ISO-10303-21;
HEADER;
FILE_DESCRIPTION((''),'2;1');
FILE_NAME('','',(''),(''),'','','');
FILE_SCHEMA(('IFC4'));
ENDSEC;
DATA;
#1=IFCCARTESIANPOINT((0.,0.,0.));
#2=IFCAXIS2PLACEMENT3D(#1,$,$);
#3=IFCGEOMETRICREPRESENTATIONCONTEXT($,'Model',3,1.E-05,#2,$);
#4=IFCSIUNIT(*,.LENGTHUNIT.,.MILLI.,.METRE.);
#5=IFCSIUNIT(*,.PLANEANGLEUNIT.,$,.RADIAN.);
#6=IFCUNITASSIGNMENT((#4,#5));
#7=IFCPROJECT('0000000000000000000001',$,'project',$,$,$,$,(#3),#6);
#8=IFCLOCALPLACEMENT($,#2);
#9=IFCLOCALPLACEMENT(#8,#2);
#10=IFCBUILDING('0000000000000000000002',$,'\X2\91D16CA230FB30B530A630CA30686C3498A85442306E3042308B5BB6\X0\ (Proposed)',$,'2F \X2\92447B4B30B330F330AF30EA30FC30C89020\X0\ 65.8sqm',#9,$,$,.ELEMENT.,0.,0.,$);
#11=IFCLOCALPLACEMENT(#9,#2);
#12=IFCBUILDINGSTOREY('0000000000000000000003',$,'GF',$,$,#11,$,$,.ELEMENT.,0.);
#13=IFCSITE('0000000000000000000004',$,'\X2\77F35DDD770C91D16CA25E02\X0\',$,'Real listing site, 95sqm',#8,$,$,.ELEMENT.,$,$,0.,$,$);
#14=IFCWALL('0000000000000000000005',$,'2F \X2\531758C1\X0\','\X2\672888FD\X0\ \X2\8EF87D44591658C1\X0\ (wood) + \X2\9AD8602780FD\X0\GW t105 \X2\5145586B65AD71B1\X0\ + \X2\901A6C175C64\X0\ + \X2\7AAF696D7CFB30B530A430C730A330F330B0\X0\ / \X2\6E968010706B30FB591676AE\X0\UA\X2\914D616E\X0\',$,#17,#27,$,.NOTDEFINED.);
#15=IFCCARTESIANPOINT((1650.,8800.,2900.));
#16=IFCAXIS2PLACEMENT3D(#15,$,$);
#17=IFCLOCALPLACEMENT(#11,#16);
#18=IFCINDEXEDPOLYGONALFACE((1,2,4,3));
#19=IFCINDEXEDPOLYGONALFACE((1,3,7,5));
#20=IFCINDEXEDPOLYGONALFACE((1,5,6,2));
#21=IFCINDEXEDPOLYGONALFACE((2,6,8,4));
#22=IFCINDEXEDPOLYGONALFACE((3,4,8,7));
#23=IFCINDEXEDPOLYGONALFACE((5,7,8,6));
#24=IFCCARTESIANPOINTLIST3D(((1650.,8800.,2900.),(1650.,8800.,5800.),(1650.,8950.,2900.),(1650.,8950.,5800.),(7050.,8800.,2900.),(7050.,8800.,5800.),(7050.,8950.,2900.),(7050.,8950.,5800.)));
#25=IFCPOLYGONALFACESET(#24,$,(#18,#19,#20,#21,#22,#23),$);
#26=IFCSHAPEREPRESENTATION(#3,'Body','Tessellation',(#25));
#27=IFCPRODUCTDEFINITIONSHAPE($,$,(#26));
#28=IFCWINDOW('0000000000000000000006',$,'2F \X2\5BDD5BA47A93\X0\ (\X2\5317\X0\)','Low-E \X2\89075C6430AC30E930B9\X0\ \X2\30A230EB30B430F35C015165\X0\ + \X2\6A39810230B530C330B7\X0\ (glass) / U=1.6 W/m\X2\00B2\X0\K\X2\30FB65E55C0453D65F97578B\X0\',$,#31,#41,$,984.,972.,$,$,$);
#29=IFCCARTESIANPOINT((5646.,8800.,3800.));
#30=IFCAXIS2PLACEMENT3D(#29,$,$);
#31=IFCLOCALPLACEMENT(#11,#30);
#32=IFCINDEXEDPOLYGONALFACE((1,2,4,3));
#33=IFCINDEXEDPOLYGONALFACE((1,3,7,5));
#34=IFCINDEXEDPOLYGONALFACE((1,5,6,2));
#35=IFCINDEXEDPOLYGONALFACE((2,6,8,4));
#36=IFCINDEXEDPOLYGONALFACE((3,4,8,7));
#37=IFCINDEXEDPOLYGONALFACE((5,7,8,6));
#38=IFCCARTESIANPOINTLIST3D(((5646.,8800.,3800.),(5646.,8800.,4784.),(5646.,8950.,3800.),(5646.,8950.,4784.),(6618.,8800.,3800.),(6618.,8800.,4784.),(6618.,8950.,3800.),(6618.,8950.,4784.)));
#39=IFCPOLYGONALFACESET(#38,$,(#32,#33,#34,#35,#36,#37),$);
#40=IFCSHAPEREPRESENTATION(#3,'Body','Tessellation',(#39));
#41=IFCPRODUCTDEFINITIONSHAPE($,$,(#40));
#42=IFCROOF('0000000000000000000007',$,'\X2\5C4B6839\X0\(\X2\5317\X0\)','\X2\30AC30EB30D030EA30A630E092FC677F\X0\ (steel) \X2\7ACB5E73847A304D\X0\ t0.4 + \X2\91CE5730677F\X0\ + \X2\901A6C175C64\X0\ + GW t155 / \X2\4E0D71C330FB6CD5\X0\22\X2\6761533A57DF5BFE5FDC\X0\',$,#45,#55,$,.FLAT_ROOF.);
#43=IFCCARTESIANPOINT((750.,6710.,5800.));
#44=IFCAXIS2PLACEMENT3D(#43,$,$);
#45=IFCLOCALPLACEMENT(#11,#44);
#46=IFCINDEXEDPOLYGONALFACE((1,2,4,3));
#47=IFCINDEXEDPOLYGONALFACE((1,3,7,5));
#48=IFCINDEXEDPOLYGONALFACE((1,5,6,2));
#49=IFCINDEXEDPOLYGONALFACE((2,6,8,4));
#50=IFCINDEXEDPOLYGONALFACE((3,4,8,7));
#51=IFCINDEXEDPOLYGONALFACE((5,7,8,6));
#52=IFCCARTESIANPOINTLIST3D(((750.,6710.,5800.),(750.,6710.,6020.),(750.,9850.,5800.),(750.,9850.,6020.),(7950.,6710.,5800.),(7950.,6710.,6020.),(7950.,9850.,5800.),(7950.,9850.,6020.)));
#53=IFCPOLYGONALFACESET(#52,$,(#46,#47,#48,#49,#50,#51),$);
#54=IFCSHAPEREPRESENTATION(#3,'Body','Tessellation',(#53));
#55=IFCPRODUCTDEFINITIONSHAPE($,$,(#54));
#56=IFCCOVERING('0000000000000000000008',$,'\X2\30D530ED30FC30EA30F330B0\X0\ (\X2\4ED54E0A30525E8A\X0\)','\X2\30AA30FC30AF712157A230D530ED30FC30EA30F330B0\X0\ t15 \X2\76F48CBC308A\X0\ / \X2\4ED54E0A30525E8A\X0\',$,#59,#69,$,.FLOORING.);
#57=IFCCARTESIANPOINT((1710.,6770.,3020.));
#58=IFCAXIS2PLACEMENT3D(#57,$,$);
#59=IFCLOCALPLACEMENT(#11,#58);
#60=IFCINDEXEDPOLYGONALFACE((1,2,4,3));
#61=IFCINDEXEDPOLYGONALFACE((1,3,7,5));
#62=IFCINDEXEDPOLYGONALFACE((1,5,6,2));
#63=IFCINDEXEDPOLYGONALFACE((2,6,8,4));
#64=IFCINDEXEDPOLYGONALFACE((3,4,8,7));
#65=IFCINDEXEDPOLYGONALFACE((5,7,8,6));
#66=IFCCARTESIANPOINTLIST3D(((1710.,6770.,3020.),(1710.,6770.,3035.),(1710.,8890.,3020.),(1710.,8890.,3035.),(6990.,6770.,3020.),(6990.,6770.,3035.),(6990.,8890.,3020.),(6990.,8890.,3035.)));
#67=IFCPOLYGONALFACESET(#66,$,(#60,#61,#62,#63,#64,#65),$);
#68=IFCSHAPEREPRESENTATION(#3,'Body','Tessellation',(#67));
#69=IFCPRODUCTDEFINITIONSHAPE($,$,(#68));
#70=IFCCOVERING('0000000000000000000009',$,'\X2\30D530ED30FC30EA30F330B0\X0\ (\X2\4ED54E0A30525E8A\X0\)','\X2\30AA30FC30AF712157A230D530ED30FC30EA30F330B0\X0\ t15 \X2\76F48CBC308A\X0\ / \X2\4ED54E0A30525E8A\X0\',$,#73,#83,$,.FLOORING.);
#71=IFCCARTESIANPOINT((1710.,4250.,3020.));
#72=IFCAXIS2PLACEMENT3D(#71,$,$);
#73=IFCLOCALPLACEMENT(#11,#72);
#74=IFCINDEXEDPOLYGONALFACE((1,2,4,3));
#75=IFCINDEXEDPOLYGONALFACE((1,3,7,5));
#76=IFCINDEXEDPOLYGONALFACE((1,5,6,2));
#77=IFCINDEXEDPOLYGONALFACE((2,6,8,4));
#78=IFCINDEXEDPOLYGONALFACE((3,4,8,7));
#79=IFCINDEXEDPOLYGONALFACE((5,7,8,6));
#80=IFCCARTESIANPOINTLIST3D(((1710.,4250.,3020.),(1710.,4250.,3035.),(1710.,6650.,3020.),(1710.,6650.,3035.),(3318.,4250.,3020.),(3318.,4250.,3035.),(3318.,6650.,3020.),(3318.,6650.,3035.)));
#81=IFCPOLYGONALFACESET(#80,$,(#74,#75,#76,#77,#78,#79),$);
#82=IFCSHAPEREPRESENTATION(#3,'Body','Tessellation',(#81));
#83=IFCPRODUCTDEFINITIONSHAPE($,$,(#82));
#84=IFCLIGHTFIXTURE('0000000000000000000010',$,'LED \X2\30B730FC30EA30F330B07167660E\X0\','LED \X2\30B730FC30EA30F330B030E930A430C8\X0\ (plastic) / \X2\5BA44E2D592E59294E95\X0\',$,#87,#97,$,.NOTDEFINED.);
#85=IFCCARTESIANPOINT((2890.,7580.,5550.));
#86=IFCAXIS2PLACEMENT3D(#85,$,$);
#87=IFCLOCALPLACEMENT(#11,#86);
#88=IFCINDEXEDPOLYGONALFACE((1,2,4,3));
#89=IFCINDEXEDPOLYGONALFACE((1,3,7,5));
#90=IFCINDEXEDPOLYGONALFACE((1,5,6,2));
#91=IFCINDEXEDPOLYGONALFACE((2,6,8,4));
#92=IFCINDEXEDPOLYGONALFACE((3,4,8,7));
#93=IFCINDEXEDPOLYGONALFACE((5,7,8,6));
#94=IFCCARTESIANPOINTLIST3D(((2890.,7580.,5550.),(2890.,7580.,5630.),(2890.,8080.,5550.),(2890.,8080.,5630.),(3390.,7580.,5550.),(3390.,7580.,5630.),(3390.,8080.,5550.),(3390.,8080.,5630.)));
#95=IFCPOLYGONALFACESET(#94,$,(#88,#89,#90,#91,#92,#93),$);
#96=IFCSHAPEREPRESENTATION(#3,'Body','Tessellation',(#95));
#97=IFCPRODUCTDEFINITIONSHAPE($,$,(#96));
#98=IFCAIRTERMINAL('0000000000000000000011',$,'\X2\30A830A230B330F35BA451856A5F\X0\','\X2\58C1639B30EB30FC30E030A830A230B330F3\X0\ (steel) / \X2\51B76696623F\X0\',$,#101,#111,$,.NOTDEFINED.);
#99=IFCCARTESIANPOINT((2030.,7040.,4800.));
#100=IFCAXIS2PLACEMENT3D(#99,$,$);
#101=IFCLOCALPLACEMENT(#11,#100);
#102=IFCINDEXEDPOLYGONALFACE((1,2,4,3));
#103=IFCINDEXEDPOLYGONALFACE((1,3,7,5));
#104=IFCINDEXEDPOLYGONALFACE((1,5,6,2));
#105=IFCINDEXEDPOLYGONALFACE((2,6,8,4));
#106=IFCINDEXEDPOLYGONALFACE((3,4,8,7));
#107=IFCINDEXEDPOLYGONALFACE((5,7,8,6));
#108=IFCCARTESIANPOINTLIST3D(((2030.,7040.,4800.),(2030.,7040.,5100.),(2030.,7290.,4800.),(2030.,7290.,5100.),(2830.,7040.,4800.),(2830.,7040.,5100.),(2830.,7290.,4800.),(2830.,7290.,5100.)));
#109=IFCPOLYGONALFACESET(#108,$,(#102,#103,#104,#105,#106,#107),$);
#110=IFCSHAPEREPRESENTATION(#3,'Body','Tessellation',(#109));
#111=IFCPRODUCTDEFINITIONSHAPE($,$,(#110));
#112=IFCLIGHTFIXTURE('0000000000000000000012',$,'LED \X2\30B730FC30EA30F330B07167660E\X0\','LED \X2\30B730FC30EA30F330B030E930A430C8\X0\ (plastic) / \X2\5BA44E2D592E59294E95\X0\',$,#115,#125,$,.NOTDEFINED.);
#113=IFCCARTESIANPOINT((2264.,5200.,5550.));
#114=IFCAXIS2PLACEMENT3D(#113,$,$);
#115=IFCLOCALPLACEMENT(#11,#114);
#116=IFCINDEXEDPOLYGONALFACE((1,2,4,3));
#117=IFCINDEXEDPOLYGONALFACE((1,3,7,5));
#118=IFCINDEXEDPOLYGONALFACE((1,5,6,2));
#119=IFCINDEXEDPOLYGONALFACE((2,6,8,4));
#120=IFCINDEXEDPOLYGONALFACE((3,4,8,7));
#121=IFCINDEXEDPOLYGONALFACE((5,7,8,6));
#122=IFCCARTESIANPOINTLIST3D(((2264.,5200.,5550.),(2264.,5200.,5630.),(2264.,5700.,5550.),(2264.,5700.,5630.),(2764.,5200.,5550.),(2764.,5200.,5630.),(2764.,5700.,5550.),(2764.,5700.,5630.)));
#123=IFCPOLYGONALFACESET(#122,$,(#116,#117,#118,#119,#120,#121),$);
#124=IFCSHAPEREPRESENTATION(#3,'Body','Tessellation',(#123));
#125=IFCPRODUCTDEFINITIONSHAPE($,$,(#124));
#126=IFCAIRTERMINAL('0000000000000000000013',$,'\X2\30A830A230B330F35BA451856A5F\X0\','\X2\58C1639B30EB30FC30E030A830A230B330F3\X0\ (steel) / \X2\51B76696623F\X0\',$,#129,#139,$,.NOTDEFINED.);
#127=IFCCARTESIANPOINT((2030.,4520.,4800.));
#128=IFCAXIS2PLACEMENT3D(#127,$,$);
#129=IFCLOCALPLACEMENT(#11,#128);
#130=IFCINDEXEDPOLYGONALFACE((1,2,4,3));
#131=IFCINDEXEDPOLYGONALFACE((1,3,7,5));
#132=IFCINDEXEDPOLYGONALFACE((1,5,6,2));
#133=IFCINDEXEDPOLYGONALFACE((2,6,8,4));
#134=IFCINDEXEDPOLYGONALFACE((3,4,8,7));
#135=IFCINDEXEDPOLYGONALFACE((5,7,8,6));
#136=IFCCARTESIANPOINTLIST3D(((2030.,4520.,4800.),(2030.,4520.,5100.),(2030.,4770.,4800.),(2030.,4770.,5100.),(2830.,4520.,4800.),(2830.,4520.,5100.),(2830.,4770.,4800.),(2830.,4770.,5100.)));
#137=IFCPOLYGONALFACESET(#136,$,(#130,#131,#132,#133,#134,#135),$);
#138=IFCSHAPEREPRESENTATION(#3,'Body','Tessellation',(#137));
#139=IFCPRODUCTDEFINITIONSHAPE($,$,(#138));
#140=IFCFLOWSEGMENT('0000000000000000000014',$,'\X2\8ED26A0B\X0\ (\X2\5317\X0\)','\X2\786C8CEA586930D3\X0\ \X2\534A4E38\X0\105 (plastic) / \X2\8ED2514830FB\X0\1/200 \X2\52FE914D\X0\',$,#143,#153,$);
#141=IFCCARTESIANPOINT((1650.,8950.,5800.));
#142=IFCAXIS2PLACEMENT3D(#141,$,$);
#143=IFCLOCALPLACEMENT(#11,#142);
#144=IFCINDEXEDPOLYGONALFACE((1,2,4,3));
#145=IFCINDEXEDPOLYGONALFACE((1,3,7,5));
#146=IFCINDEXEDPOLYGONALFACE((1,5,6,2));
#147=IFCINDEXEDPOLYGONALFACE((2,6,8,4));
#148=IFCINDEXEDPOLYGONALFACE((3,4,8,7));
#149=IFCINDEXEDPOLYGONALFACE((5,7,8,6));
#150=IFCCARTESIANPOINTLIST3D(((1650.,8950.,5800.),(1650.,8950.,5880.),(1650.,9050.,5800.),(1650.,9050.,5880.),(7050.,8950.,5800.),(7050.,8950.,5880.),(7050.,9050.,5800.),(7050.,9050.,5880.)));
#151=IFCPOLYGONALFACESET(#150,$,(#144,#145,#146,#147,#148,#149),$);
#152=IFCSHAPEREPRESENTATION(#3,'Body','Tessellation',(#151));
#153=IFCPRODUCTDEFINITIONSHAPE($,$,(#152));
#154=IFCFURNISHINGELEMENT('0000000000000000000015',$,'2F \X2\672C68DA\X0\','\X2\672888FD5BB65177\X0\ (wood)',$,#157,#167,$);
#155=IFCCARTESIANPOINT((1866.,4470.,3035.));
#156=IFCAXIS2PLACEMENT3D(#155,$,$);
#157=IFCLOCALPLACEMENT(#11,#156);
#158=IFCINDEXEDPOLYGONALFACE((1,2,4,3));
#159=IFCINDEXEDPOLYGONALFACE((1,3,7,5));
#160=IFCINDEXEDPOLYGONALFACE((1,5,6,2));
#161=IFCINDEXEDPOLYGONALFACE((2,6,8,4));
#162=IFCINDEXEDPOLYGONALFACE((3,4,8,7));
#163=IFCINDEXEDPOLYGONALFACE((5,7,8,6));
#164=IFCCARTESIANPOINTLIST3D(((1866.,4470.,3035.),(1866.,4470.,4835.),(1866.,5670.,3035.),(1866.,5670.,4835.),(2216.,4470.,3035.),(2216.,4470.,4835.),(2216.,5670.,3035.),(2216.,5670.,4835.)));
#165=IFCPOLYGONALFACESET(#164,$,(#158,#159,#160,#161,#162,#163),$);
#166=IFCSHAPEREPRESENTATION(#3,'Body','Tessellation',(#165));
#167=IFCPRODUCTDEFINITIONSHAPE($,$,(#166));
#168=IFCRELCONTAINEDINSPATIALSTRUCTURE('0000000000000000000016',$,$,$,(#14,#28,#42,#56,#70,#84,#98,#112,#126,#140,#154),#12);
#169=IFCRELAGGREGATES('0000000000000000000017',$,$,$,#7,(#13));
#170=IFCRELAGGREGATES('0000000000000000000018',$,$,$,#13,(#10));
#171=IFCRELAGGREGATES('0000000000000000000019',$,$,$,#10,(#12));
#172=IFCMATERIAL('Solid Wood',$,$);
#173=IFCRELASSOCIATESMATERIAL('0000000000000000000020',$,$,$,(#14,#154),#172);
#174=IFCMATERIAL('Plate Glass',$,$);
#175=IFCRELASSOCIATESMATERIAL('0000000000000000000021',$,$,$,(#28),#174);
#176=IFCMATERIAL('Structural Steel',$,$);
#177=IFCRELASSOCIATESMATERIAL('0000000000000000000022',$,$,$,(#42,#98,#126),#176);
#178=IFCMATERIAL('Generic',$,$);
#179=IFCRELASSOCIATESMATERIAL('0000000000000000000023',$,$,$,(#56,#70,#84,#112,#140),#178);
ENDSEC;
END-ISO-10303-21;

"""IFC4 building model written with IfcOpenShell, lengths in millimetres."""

from ifc_helpers import new_model, si_unit, frame, frame_2d, origin, place, context, project, spatial, rectangle, extrude, material, element, fill, save


model = new_model("IFC4")

# Units and contexts
model_context = context("Model", 3, precision=1e-05, world=origin())
ifc_project = project(units=[si_unit("LENGTHUNIT", "METRE", prefix="MILLI"), si_unit("PLANEANGLEUNIT", "RADIAN")], contexts=[model_context])

# Site, building, storey
site_placement = place(None, origin())
site = spatial("IfcSite", under=ifc_project, at=site_placement, Name="石川県金沢市", ObjectType="Real listing site, 95sqm", CompositionType="ELEMENT", RefElevation=0.0)
building_placement = place(site_placement, origin())
building = spatial("IfcBuilding", under=site, at=building_placement, Name="金沢・サウナと水風呂のある家 (Proposed)", ObjectType="2F 鉄筋コンクリート造 65.8sqm", CompositionType="ELEMENT", ElevationOfRefHeight=0.0, ElevationOfTerrain=0.0)
storey_placement = place(building_placement, origin())
storey = spatial("IfcBuildingStorey", under=building, at=storey_placement, Name="GF", CompositionType="ELEMENT", Elevation=0.0)

# Shared definitions
ifc_material_1 = material(Name="Solid Wood")

# Wall, opening, window
wall_placement = place(storey_placement, frame((1650.0, 8800.0, 2900.0)))
wall = element("IfcWall", 1, at=wall_placement, inside=storey, material=ifc_material_1, Name="2F 北壁", Description="木製 軸組外壁 (wood) + 高性能GW t105 充填断熱 + 通気層 + 窯業系サイディング / 準耐火・外皮UA配慮", PredefinedType="NOTDEFINED", context=model_context, shape_type="SweptSolid", body=[
    extrude(rectangle(XDim=5400.0, YDim=150.0, at=frame_2d((2700.0, 75.0))), frame((1650.0, 8800.0, 2900.0)), (0.0, 0.0, 1.0), 2900.0),
])
opening_placement = place(storey_placement, frame((5646.0, 8800.0, 3800.0)))
opening = element("IfcOpeningElement", 2, at=opening_placement, cuts=wall, PredefinedType="NOTDEFINED", context=model_context, shape_type="SweptSolid", body=[
    extrude(rectangle(XDim=972.0, YDim=150.0, at=frame_2d((486.0, 75.0))), frame((5646.0, 8800.0, 3800.0)), (0.0, 0.0, 1.0), 984.0),
])
ifc_material_2 = material(Name="Plate Glass")
window_placement = place(storey_placement, frame((5646.0, 8800.0, 3800.0)))
window = element("IfcWindow", 3, at=window_placement, inside=storey, material=ifc_material_2, Name="2F 寝室窓 (北)", Description="Low-E 複層ガラス アルゴン封入 + 樹脂サッシ (glass) / U=1.6 W/m²K・日射取得型", OverallHeight=984.0, OverallWidth=972.0, context=model_context, shape_type="SweptSolid", body=[
    extrude(rectangle(XDim=972.0, YDim=150.0, at=frame_2d((486.0, 75.0))), frame((5646.0, 8800.0, 3800.0)), (0.0, 0.0, 1.0), 984.0),
])
fill(opening, window)

# Roof
ifc_material_3 = material(Name="Structural Steel")
for number, where, name in (
    (4, (750.0, 6710.0, 5800.0), "屋根(北)"),
):
    element("IfcRoof", number, at=place(storey_placement, frame(where)), inside=storey, material=ifc_material_3, Name=name, Description="ガルバリウム鋼板 (steel) 立平葺き t0.4 + 野地板 + 通気層 + GW t155 / 不燃・法22条区域対応", PredefinedType="FLAT_ROOF", context=model_context, shape_type="SweptSolid", body=[
        extrude(rectangle(XDim=7200.0, YDim=3140.0, at=frame_2d((3600.0, 1570.0))), frame((750.0, 6710.0, 5800.0)), (0.0, 0.0, 1.0), 220.0),
    ])

# Coverings
ifc_material_4 = material(Name="Generic")
covering_1_placement = place(storey_placement, frame((1710.0, 6770.0, 3020.0)))
element("IfcCovering", 5, at=covering_1_placement, inside=storey, material=ifc_material_4, Name="フローリング (仕上げ床)", Description="オーク無垢フローリング t15 直貼り / 仕上げ床", PredefinedType="FLOORING", context=model_context, shape_type="SweptSolid", body=[
    extrude(rectangle(XDim=5280.0, YDim=2120.0, at=frame_2d((2640.0, 1060.0))), frame((1710.0, 6770.0, 3020.0)), (0.0, 0.0, 1.0), 15.0),
])
covering_2_placement = place(storey_placement, frame((1710.0, 4250.0, 3020.0)))
element("IfcCovering", 6, at=covering_2_placement, inside=storey, material=ifc_material_4, Name="フローリング (仕上げ床)", Description="オーク無垢フローリング t15 直貼り / 仕上げ床", PredefinedType="FLOORING", context=model_context, shape_type="SweptSolid", body=[
    extrude(rectangle(XDim=1608.0, YDim=2400.0, at=frame_2d((804.0, 1200.0))), frame((1710.0, 4250.0, 3020.0)), (0.0, 0.0, 1.0), 15.0),
])

# Light fixture
light_fixture_1_placement = place(storey_placement, frame((2890.0, 7580.0, 5550.0)))
element("IfcLightFixture", 7, at=light_fixture_1_placement, inside=storey, material=ifc_material_4, Name="LED シーリング照明", Description="LED シーリングライト (plastic) / 室中央天井", PredefinedType="NOTDEFINED", context=model_context, shape_type="SweptSolid", body=[
    extrude(rectangle(XDim=500.0, YDim=500.0, at=frame_2d((250.0, 250.0))), frame((2890.0, 7580.0, 5550.0)), (0.0, 0.0, 1.0), 80.0),
])

# Air terminal
air_terminal_1_placement = place(storey_placement, frame((2030.0, 7040.0, 4800.0)))
element("IfcAirTerminal", 8, at=air_terminal_1_placement, inside=storey, material=ifc_material_3, Name="エアコン室内機", Description="壁掛ルームエアコン (steel) / 冷暖房", PredefinedType="NOTDEFINED", context=model_context, shape_type="SweptSolid", body=[
    extrude(rectangle(XDim=800.0, YDim=250.0, at=frame_2d((400.0, 125.0))), frame((2030.0, 7040.0, 4800.0)), (0.0, 0.0, 1.0), 300.0),
])

# Light fixture
light_fixture_2_placement = place(storey_placement, frame((2264.0, 5200.0, 5550.0)))
element("IfcLightFixture", 9, at=light_fixture_2_placement, inside=storey, material=ifc_material_4, Name="LED シーリング照明", Description="LED シーリングライト (plastic) / 室中央天井", PredefinedType="NOTDEFINED", context=model_context, shape_type="SweptSolid", body=[
    extrude(rectangle(XDim=500.0, YDim=500.0, at=frame_2d((250.0, 250.0))), frame((2264.0, 5200.0, 5550.0)), (0.0, 0.0, 1.0), 80.0),
])

# Air terminal
air_terminal_2_placement = place(storey_placement, frame((2030.0, 4520.0, 4800.0)))
element("IfcAirTerminal", 10, at=air_terminal_2_placement, inside=storey, material=ifc_material_3, Name="エアコン室内機", Description="壁掛ルームエアコン (steel) / 冷暖房", PredefinedType="NOTDEFINED", context=model_context, shape_type="SweptSolid", body=[
    extrude(rectangle(XDim=800.0, YDim=250.0, at=frame_2d((400.0, 125.0))), frame((2030.0, 4520.0, 4800.0)), (0.0, 0.0, 1.0), 300.0),
])

# Flow segment
flow_segment_placement = place(storey_placement, frame((1650.0, 8950.0, 5800.0)))
element("IfcFlowSegment", 11, at=flow_segment_placement, inside=storey, material=ifc_material_4, Name="軒樋 (北)", Description="硬質塩ビ 半丸105 (plastic) / 軒先・1/200 勾配", context=model_context, shape_type="SweptSolid", body=[
    extrude(rectangle(XDim=5400.0, YDim=100.0, at=frame_2d((2700.0, 50.0))), frame((1650.0, 8950.0, 5800.0)), (0.0, 0.0, 1.0), 80.0),
])

# Furnishing element
furnishing_placement = place(storey_placement, frame((1866.0, 4470.0, 3035.0)))
element("IfcFurnishingElement", 12, at=furnishing_placement, inside=storey, material=ifc_material_1, Name="2F 本棚", Description="木製家具 (wood)", context=model_context, shape_type="SweptSolid", body=[
    extrude(rectangle(XDim=350.0, YDim=1200.0, at=frame_2d((175.0, 600.0))), frame((1866.0, 4470.0, 3035.0)), (0.0, 0.0, 1.0), 1800.0),
])

save(model, "model.ifc")
